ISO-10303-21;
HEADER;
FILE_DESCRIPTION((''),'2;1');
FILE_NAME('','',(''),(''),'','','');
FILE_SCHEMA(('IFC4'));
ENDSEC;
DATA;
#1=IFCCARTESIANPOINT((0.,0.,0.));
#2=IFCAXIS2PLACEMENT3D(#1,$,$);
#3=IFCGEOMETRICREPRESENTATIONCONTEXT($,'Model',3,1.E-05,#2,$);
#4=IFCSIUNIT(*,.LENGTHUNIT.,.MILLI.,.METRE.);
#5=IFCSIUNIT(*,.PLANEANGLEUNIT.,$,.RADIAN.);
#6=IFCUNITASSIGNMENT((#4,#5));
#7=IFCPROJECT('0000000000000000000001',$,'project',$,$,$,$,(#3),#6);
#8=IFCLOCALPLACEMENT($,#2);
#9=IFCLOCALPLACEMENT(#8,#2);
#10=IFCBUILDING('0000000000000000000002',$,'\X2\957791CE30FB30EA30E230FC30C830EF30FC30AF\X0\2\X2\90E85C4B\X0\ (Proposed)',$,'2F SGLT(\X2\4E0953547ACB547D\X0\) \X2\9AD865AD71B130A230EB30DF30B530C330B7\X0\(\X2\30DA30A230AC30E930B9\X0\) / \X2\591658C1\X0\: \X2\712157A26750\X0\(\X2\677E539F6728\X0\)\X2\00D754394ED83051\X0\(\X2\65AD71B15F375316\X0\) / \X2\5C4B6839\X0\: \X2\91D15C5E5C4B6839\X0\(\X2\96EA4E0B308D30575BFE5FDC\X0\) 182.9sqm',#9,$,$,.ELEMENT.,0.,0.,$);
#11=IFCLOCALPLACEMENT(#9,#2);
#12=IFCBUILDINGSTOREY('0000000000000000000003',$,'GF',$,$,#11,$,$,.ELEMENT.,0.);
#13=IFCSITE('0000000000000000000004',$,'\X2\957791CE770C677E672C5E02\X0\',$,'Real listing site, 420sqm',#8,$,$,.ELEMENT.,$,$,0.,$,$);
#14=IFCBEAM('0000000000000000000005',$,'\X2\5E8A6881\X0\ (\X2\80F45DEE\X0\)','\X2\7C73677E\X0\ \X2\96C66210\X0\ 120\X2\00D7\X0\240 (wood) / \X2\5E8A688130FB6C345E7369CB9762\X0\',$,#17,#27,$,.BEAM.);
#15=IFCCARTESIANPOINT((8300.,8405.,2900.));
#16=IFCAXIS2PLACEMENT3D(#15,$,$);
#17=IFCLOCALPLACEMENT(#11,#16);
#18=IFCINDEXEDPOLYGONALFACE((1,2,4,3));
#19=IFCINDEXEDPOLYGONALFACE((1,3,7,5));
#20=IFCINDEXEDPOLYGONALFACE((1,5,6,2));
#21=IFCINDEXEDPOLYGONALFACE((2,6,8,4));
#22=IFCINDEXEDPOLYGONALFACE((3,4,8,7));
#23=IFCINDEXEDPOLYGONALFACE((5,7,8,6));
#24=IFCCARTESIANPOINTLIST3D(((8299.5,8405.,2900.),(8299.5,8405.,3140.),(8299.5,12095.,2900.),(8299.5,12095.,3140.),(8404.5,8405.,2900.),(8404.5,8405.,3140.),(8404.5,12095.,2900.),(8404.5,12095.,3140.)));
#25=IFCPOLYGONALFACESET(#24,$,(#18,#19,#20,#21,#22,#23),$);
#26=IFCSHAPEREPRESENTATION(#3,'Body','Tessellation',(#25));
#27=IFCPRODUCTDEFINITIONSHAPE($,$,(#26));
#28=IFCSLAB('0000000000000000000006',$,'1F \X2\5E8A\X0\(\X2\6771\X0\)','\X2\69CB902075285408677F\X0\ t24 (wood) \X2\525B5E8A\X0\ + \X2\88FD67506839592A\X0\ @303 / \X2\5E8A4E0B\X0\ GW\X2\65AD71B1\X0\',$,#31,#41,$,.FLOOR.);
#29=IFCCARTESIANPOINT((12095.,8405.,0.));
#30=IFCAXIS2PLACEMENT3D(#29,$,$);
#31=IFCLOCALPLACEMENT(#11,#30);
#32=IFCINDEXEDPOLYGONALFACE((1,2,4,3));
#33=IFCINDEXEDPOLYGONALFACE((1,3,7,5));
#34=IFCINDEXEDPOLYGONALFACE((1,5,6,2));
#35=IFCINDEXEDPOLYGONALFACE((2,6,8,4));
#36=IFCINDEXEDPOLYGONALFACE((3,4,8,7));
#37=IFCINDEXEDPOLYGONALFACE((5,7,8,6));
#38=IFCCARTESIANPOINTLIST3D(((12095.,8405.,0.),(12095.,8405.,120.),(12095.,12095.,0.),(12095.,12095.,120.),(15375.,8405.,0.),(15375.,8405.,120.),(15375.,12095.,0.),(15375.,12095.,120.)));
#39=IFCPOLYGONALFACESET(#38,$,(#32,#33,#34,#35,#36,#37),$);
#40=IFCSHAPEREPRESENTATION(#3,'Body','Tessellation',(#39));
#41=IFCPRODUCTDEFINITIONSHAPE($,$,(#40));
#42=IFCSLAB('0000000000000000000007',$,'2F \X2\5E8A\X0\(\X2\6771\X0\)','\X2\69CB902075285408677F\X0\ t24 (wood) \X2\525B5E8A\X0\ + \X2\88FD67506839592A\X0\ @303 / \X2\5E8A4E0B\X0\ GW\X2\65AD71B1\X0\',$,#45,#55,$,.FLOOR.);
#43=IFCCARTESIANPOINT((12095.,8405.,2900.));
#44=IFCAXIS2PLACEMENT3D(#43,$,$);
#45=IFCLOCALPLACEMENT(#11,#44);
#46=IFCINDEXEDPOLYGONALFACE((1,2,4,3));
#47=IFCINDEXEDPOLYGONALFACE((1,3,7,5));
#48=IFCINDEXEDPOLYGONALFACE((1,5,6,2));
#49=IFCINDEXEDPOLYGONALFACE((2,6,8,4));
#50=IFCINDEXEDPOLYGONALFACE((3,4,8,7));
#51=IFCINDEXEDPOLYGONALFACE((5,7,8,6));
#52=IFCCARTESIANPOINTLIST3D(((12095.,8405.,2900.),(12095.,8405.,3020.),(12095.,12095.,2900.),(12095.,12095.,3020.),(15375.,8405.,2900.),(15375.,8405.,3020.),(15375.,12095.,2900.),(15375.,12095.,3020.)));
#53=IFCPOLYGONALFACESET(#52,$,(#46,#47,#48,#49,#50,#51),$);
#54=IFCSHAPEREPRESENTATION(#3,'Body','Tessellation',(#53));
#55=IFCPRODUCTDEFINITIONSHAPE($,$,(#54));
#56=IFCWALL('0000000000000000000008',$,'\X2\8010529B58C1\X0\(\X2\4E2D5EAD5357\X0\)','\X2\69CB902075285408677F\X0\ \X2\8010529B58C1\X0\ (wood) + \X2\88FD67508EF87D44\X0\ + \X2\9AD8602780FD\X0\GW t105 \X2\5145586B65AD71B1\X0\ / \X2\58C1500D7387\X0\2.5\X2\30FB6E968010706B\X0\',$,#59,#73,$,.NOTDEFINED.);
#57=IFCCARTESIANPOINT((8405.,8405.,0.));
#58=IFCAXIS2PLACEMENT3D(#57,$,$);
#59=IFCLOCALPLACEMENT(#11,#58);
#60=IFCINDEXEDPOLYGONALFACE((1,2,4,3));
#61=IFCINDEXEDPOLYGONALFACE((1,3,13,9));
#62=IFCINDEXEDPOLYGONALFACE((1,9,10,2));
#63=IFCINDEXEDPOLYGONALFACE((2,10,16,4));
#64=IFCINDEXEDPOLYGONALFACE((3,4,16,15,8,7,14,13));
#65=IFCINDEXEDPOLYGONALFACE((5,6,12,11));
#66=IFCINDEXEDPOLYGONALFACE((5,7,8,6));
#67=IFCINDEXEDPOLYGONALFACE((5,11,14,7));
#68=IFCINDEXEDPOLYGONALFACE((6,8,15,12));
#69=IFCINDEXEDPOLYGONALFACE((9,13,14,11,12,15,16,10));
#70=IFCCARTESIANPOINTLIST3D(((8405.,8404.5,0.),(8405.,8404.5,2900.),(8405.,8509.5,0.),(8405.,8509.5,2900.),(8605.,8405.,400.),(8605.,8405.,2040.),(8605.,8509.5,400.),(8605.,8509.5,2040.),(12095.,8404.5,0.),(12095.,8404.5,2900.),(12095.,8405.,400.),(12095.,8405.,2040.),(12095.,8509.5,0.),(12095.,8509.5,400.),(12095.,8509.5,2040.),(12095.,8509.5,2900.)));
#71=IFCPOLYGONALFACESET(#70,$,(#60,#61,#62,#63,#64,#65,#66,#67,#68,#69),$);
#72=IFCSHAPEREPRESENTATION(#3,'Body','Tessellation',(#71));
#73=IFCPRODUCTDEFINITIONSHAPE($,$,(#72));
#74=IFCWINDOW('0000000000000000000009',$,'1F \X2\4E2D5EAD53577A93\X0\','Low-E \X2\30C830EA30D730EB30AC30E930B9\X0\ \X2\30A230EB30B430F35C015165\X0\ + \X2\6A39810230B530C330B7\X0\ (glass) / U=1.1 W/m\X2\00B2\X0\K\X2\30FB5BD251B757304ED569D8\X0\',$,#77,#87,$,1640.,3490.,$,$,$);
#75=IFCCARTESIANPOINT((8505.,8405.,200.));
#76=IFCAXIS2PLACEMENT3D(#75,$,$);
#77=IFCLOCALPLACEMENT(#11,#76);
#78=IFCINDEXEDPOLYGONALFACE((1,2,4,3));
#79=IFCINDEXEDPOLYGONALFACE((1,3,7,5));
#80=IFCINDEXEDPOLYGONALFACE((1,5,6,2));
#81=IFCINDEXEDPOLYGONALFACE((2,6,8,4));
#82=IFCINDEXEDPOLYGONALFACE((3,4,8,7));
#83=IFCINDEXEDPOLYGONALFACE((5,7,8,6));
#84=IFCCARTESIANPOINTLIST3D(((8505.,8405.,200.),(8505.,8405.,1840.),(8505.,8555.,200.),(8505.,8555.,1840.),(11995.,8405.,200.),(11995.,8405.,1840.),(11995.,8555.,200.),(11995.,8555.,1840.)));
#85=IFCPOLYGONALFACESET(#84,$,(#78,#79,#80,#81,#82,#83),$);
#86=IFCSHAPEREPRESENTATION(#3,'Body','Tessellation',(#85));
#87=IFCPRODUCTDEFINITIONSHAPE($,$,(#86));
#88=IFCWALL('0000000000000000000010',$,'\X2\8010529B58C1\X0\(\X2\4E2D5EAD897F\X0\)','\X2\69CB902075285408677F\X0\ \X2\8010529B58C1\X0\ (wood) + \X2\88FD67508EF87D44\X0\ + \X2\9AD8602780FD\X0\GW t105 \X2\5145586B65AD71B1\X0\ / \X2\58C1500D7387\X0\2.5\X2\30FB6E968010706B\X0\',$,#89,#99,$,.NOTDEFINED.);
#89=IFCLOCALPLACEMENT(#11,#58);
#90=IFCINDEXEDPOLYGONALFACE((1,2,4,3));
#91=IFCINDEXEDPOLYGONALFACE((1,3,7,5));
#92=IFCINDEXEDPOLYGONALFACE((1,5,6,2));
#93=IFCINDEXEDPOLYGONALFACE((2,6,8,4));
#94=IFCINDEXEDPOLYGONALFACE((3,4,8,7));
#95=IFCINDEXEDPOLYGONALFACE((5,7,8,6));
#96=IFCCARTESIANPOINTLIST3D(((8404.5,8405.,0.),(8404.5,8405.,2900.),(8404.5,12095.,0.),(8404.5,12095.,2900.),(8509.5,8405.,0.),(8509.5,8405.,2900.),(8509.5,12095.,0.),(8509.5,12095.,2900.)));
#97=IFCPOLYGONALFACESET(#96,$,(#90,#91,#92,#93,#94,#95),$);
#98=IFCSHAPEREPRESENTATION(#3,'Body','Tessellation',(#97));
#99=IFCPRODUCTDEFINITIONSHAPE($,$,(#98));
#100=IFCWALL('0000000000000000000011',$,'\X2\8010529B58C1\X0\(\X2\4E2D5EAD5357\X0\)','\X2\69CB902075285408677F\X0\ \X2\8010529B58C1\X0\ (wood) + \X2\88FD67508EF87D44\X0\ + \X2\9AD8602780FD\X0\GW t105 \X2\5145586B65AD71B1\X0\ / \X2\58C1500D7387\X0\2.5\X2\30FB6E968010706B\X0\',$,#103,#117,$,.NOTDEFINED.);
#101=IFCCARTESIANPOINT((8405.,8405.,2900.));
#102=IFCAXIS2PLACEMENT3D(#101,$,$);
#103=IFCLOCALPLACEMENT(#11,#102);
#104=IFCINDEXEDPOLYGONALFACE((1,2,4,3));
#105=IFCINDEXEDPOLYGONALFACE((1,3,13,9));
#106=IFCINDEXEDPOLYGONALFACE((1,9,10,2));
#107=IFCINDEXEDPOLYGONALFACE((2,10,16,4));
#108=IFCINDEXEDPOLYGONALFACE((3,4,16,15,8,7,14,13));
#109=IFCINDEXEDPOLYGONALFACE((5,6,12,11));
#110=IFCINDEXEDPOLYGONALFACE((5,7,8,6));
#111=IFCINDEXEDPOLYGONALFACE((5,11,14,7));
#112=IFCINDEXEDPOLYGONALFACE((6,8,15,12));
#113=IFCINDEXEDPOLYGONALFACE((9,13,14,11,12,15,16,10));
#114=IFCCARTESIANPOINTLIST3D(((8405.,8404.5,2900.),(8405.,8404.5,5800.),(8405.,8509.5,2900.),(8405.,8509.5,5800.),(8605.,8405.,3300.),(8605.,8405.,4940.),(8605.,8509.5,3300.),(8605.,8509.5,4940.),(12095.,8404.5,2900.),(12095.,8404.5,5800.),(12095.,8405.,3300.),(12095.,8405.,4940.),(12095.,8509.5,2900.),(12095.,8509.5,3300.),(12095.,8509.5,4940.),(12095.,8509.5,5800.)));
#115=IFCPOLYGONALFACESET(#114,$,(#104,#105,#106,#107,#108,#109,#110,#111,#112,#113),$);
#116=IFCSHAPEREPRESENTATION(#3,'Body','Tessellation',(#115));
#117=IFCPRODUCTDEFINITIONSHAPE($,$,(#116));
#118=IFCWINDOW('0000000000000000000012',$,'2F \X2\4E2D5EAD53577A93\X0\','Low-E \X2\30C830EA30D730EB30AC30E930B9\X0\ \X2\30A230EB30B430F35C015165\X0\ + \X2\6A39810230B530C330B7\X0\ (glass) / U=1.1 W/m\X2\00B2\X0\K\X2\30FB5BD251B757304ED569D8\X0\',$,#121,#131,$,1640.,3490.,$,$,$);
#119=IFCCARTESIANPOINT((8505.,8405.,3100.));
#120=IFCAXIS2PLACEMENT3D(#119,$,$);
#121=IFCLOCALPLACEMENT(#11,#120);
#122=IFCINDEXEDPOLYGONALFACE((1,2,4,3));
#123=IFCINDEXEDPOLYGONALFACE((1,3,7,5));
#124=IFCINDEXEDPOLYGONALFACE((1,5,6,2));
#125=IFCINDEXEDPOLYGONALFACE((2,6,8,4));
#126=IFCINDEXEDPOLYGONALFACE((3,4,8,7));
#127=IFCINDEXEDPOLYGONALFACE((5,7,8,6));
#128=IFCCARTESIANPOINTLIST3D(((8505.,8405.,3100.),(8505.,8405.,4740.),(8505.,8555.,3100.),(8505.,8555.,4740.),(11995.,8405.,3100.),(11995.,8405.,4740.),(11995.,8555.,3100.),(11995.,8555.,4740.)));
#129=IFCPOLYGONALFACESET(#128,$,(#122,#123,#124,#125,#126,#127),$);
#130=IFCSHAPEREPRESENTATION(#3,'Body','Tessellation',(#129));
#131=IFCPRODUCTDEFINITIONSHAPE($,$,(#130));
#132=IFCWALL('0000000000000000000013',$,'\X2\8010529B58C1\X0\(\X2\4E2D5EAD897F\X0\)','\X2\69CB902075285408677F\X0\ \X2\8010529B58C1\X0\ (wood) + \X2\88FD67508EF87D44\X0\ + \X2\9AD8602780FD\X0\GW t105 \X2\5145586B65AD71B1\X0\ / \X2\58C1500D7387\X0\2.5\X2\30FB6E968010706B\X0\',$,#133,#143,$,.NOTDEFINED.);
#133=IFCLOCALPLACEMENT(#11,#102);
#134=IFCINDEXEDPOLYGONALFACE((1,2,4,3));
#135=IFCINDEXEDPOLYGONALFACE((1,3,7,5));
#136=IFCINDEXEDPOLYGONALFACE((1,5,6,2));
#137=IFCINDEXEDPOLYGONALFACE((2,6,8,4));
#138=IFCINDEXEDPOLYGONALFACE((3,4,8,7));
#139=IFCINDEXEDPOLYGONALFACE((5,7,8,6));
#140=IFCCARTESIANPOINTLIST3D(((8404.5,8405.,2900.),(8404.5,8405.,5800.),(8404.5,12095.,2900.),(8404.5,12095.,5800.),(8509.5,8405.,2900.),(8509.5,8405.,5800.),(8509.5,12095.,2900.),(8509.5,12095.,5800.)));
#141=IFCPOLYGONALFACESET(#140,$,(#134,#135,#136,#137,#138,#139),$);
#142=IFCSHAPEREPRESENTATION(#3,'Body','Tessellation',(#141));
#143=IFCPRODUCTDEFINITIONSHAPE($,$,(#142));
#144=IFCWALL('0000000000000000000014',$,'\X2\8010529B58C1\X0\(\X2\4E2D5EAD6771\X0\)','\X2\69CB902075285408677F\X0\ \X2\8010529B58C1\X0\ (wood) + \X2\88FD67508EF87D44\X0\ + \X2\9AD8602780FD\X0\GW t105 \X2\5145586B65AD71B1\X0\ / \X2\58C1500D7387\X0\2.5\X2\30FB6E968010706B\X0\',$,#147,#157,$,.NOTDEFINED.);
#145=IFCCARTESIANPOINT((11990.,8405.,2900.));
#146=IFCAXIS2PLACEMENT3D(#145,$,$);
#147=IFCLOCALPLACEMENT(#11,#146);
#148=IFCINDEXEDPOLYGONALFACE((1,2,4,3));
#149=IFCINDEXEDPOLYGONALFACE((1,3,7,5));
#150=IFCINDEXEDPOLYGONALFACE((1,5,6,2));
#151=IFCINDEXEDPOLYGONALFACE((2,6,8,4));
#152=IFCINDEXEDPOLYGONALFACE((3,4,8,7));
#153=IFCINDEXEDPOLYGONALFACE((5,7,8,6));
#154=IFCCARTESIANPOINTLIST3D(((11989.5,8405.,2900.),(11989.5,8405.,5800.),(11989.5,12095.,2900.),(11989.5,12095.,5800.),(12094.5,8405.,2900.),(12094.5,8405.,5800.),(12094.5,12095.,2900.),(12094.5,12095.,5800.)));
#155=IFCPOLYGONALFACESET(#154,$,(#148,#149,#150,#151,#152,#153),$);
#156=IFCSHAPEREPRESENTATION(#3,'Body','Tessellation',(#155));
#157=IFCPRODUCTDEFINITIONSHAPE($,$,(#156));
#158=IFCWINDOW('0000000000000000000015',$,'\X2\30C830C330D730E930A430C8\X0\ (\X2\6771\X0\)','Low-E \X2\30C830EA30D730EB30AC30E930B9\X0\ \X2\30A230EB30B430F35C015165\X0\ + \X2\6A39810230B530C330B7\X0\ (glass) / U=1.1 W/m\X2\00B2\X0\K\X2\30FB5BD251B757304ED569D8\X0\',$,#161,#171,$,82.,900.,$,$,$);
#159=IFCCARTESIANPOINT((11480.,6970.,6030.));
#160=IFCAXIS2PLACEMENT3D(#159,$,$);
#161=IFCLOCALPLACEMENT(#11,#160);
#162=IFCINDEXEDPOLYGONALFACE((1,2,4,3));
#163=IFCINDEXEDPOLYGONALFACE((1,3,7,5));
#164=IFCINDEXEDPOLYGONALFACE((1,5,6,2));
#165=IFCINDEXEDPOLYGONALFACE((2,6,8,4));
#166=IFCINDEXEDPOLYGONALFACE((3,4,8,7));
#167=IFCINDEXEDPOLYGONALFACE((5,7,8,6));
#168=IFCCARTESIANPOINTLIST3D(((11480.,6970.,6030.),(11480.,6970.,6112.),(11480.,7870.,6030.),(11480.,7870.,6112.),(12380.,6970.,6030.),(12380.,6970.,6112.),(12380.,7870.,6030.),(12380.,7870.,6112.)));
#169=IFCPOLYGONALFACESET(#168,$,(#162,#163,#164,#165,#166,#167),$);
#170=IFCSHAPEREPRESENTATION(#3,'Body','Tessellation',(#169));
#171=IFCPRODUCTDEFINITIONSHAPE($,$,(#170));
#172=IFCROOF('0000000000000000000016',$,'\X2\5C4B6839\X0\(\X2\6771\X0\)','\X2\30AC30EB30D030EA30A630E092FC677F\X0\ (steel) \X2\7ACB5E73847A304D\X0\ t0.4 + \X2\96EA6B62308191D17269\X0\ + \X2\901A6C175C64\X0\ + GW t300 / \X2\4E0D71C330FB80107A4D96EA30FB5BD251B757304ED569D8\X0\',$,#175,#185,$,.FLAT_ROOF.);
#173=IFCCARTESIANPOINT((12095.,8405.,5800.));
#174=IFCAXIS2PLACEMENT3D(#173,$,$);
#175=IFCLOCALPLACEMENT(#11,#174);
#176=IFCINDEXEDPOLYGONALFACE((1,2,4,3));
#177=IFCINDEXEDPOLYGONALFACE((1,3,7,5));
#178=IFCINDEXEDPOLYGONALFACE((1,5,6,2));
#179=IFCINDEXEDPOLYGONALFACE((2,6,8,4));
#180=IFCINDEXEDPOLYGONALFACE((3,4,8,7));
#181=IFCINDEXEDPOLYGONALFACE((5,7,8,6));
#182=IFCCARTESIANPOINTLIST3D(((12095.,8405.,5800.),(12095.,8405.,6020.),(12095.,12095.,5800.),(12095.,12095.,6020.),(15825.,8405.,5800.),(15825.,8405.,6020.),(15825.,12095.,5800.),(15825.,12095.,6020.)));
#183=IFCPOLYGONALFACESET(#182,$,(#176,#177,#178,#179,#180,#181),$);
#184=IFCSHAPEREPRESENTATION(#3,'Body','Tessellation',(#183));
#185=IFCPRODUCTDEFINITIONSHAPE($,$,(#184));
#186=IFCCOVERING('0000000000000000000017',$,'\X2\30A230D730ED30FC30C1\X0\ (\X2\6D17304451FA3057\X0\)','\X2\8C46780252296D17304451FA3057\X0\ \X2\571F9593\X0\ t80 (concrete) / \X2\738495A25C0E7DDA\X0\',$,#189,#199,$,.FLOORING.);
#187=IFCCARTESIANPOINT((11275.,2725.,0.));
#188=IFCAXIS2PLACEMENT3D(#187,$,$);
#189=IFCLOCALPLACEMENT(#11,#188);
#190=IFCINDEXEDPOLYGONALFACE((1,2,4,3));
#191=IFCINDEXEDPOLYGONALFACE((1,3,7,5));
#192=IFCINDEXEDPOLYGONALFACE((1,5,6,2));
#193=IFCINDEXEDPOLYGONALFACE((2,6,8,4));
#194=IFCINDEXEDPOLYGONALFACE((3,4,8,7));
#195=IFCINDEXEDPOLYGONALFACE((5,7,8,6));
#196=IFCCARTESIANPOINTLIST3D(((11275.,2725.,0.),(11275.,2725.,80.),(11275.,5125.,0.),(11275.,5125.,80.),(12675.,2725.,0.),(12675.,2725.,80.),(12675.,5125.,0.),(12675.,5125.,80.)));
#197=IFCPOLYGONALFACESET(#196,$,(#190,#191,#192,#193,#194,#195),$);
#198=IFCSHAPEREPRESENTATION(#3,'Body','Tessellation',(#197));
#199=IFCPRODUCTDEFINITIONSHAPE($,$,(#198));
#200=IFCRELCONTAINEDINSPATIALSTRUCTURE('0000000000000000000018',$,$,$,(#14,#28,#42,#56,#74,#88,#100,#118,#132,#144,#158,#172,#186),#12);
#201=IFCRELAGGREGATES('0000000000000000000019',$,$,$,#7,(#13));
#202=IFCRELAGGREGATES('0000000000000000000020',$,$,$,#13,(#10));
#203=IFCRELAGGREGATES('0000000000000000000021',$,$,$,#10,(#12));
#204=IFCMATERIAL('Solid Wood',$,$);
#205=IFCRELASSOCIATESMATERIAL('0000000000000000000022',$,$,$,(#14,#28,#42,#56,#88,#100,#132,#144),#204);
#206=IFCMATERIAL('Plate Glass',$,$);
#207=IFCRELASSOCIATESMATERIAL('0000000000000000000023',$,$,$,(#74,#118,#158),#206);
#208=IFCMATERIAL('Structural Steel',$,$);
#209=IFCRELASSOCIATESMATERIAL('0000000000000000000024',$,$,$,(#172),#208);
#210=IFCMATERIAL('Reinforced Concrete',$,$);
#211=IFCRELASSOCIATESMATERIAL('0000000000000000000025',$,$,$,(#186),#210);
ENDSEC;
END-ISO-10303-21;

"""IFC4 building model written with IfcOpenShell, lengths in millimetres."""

from ifc_helpers import new_model, si_unit, frame, frame_2d, origin, place, context, project, spatial, rectangle, extrude, material, element, fill, save


model = new_model("IFC4")

# Units and contexts
model_context = context("Model", 3, precision=1e-05, world=origin())
ifc_project = project(units=[si_unit("LENGTHUNIT", "METRE", prefix="MILLI"), si_unit("PLANEANGLEUNIT", "RADIAN")], contexts=[model_context])

# Site, building, storey
site_placement = place(None, origin())
site = spatial("IfcSite", under=ifc_project, at=site_placement, Name="長野県松本市", ObjectType="Real listing site, 420sqm", CompositionType="ELEMENT", RefElevation=0.0)
building_placement = place(site_placement, origin())
building = spatial("IfcBuilding", under=site, at=building_placement, Name="長野・リモートワーク2部屋 (Proposed)", ObjectType="2F SGLT(三協立命) 高断熱アルミサッシ(ペアガラス) / 外壁: 無垢材(松原木)×吹付け(断熱強化) / 屋根: 金属屋根(雪下ろし対応) 182.9sqm", CompositionType="ELEMENT", ElevationOfRefHeight=0.0, ElevationOfTerrain=0.0)
storey_placement = place(building_placement, origin())
storey = spatial("IfcBuildingStorey", under=building, at=storey_placement, Name="GF", CompositionType="ELEMENT", Elevation=0.0)

# Shared definitions
ifc_material_1 = material(Name="Solid Wood")

# Beam
beam_placement = place(storey_placement, frame((8300.0, 8405.0, 2900.0)))
element("IfcBeam", 1, at=beam_placement, inside=storey, material=ifc_material_1, Name="床梁 (胴差)", Description="米松 集成 120×240 (wood) / 床梁・水平構面", PredefinedType="BEAM", context=model_context, shape_type="SweptSolid", body=[
    extrude(rectangle(XDim=105.0, YDim=3690.0, at=frame_2d((52.0, 1845.0))), frame((8300.0, 8405.0, 2900.0)), (0.0, 0.0, 1.0), 240.0),
])

# Slabs
slab_1_placement = place(storey_placement, frame((12095.0, 8405.0, 0.0)))
element("IfcSlab", 2, at=slab_1_placement, inside=storey, material=ifc_material_1, Name="1F 床(東)", Description="構造用合板 t24 (wood) 剛床 + 製材根太 @303 / 床下 GW断熱", PredefinedType="FLOOR", context=model_context, shape_type="SweptSolid", body=[
    extrude(rectangle(XDim=3280.0, YDim=3690.0, at=frame_2d((1640.0, 1845.0))), frame((12095.0, 8405.0, 0.0)), (0.0, 0.0, 1.0), 120.0),
])
slab_2_placement = place(storey_placement, frame((12095.0, 8405.0, 2900.0)))
element("IfcSlab", 3, at=slab_2_placement, inside=storey, material=ifc_material_1, Name="2F 床(東)", Description="構造用合板 t24 (wood) 剛床 + 製材根太 @303 / 床下 GW断熱", PredefinedType="FLOOR", context=model_context, shape_type="SweptSolid", body=[
    extrude(rectangle(XDim=3280.0, YDim=3690.0, at=frame_2d((1640.0, 1845.0))), frame((12095.0, 8405.0, 2900.0)), (0.0, 0.0, 1.0), 120.0),
])

# Wall, opening, window
wall_1_placement = place(storey_placement, frame((8405.0, 8405.0, 0.0)))
wall_1 = element("IfcWall", 4, at=wall_1_placement, inside=storey, material=ifc_material_1, Name="耐力壁(中庭南)", Description="構造用合板 耐力壁 (wood) + 製材軸組 + 高性能GW t105 充填断熱 / 壁倍率2.5・準耐火", PredefinedType="NOTDEFINED", context=model_context, shape_type="SweptSolid", body=[
    extrude(rectangle(XDim=3690.0, YDim=105.0, at=frame_2d((1845.0, 52.0))), frame((8405.0, 8405.0, 0.0)), (0.0, 0.0, 1.0), 2900.0),
])
opening_1_placement = place(storey_placement, frame((8505.0, 8405.0, 200.0)))
opening_1 = element("IfcOpeningElement", 5, at=opening_1_placement, cuts=wall_1, PredefinedType="NOTDEFINED", context=model_context, shape_type="SweptSolid", body=[
    extrude(rectangle(XDim=3490.0, YDim=150.0, at=frame_2d((1745.0, 75.0))), frame((8505.0, 8405.0, 200.0)), (0.0, 0.0, 1.0), 1640.0),
])
ifc_material_2 = material(Name="Plate Glass")
window_1_placement = place(storey_placement, frame((8505.0, 8405.0, 200.0)))
window_1 = element("IfcWindow", 6, at=window_1_placement, inside=storey, material=ifc_material_2, Name="1F 中庭南窓", Description="Low-E トリプルガラス アルゴン封入 + 樹脂サッシ (glass) / U=1.1 W/m²K・寒冷地仕様", OverallHeight=1640.0, OverallWidth=3490.0, context=model_context, shape_type="SweptSolid", body=[
    extrude(rectangle(XDim=3490.0, YDim=150.0, at=frame_2d((1745.0, 75.0))), frame((8505.0, 8405.0, 200.0)), (0.0, 0.0, 1.0), 1640.0),
])
fill(opening_1, window_1)

# Wall
wall_2_placement = place(storey_placement, frame((8405.0, 8405.0, 0.0)))
element("IfcWall", 7, at=wall_2_placement, inside=storey, material=ifc_material_1, Name="耐力壁(中庭西)", Description="構造用合板 耐力壁 (wood) + 製材軸組 + 高性能GW t105 充填断熱 / 壁倍率2.5・準耐火", PredefinedType="NOTDEFINED", context=model_context, shape_type="SweptSolid", body=[
    extrude(rectangle(XDim=105.0, YDim=3690.0, at=frame_2d((52.0, 1845.0))), frame((8405.0, 8405.0, 0.0)), (0.0, 0.0, 1.0), 2900.0),
])

# Wall, opening, window
wall_3_placement = place(storey_placement, frame((8405.0, 8405.0, 2900.0)))
wall_3 = element("IfcWall", 8, at=wall_3_placement, inside=storey, material=ifc_material_1, Name="耐力壁(中庭南)", Description="構造用合板 耐力壁 (wood) + 製材軸組 + 高性能GW t105 充填断熱 / 壁倍率2.5・準耐火", PredefinedType="NOTDEFINED", context=model_context, shape_type="SweptSolid", body=[
    extrude(rectangle(XDim=3690.0, YDim=105.0, at=frame_2d((1845.0, 52.0))), frame((8405.0, 8405.0, 2900.0)), (0.0, 0.0, 1.0), 2900.0),
])
opening_2_placement = place(storey_placement, frame((8505.0, 8405.0, 3100.0)))
opening_2 = element("IfcOpeningElement", 9, at=opening_2_placement, cuts=wall_3, PredefinedType="NOTDEFINED", context=model_context, shape_type="SweptSolid", body=[
    extrude(rectangle(XDim=3490.0, YDim=150.0, at=frame_2d((1745.0, 75.0))), frame((8505.0, 8405.0, 3100.0)), (0.0, 0.0, 1.0), 1640.0),
])
window_2_placement = place(storey_placement, frame((8505.0, 8405.0, 3100.0)))
window_2 = element("IfcWindow", 10, at=window_2_placement, inside=storey, material=ifc_material_2, Name="2F 中庭南窓", Description="Low-E トリプルガラス アルゴン封入 + 樹脂サッシ (glass) / U=1.1 W/m²K・寒冷地仕様", OverallHeight=1640.0, OverallWidth=3490.0, context=model_context, shape_type="SweptSolid", body=[
    extrude(rectangle(XDim=3490.0, YDim=150.0, at=frame_2d((1745.0, 75.0))), frame((8505.0, 8405.0, 3100.0)), (0.0, 0.0, 1.0), 1640.0),
])
fill(opening_2, window_2)

# Walls
wall_4_placement = place(storey_placement, frame((8405.0, 8405.0, 2900.0)))
element("IfcWall", 11, at=wall_4_placement, inside=storey, material=ifc_material_1, Name="耐力壁(中庭西)", Description="構造用合板 耐力壁 (wood) + 製材軸組 + 高性能GW t105 充填断熱 / 壁倍率2.5・準耐火", PredefinedType="NOTDEFINED", context=model_context, shape_type="SweptSolid", body=[
    extrude(rectangle(XDim=105.0, YDim=3690.0, at=frame_2d((52.0, 1845.0))), frame((8405.0, 8405.0, 2900.0)), (0.0, 0.0, 1.0), 2900.0),
])
wall_5_placement = place(storey_placement, frame((11990.0, 8405.0, 2900.0)))
element("IfcWall", 12, at=wall_5_placement, inside=storey, material=ifc_material_1, Name="耐力壁(中庭東)", Description="構造用合板 耐力壁 (wood) + 製材軸組 + 高性能GW t105 充填断熱 / 壁倍率2.5・準耐火", PredefinedType="NOTDEFINED", context=model_context, shape_type="SweptSolid", body=[
    extrude(rectangle(XDim=105.0, YDim=3690.0, at=frame_2d((52.0, 1845.0))), frame((11990.0, 8405.0, 2900.0)), (0.0, 0.0, 1.0), 2900.0),
])

# Window
window_3_placement = place(storey_placement, frame((11480.0, 6970.0, 6030.0)))
element("IfcWindow", 13, at=window_3_placement, inside=storey, material=ifc_material_2, Name="トップライト (東)", Description="Low-E トリプルガラス アルゴン封入 + 樹脂サッシ (glass) / U=1.1 W/m²K・寒冷地仕様", OverallHeight=82.0, OverallWidth=900.0, context=model_context, shape_type="SweptSolid", body=[
    extrude(rectangle(XDim=900.0, YDim=900.0, at=frame_2d((450.0, 450.0))), frame((11480.0, 6970.0, 6030.0)), (0.0, 0.0, 1.0), 82.0),
])

# Roof
ifc_material_3 = material(Name="Structural Steel")
roof_placement = place(storey_placement, frame((12095.0, 8405.0, 5800.0)))
element("IfcRoof", 14, at=roof_placement, inside=storey, material=ifc_material_3, Name="屋根(東)", Description="ガルバリウム鋼板 (steel) 立平葺き t0.4 + 雪止め金物 + 通気層 + GW t300 / 不燃・耐積雪・寒冷地仕様", PredefinedType="FLAT_ROOF", context=model_context, shape_type="SweptSolid", body=[
    extrude(rectangle(XDim=3730.0, YDim=3690.0, at=frame_2d((1865.0, 1845.0))), frame((12095.0, 8405.0, 5800.0)), (0.0, 0.0, 1.0), 220.0),
])

# Covering
ifc_material_4 = material(Name="Reinforced Concrete")
covering_placement = place(storey_placement, frame((11275.0, 2725.0, 0.0)))
element("IfcCovering", 15, at=covering_placement, inside=storey, material=ifc_material_4, Name="アプローチ (洗い出し)", Description="豆砂利洗い出し 土間 t80 (concrete) / 玄関導線", PredefinedType="FLOORING", context=model_context, shape_type="SweptSolid", body=[
    extrude(rectangle(XDim=1400.0, YDim=2400.0, at=frame_2d((700.0, 1200.0))), frame((11275.0, 2725.0, 0.0)), (0.0, 0.0, 1.0), 80.0),
])

save(model, "model.ifc")
